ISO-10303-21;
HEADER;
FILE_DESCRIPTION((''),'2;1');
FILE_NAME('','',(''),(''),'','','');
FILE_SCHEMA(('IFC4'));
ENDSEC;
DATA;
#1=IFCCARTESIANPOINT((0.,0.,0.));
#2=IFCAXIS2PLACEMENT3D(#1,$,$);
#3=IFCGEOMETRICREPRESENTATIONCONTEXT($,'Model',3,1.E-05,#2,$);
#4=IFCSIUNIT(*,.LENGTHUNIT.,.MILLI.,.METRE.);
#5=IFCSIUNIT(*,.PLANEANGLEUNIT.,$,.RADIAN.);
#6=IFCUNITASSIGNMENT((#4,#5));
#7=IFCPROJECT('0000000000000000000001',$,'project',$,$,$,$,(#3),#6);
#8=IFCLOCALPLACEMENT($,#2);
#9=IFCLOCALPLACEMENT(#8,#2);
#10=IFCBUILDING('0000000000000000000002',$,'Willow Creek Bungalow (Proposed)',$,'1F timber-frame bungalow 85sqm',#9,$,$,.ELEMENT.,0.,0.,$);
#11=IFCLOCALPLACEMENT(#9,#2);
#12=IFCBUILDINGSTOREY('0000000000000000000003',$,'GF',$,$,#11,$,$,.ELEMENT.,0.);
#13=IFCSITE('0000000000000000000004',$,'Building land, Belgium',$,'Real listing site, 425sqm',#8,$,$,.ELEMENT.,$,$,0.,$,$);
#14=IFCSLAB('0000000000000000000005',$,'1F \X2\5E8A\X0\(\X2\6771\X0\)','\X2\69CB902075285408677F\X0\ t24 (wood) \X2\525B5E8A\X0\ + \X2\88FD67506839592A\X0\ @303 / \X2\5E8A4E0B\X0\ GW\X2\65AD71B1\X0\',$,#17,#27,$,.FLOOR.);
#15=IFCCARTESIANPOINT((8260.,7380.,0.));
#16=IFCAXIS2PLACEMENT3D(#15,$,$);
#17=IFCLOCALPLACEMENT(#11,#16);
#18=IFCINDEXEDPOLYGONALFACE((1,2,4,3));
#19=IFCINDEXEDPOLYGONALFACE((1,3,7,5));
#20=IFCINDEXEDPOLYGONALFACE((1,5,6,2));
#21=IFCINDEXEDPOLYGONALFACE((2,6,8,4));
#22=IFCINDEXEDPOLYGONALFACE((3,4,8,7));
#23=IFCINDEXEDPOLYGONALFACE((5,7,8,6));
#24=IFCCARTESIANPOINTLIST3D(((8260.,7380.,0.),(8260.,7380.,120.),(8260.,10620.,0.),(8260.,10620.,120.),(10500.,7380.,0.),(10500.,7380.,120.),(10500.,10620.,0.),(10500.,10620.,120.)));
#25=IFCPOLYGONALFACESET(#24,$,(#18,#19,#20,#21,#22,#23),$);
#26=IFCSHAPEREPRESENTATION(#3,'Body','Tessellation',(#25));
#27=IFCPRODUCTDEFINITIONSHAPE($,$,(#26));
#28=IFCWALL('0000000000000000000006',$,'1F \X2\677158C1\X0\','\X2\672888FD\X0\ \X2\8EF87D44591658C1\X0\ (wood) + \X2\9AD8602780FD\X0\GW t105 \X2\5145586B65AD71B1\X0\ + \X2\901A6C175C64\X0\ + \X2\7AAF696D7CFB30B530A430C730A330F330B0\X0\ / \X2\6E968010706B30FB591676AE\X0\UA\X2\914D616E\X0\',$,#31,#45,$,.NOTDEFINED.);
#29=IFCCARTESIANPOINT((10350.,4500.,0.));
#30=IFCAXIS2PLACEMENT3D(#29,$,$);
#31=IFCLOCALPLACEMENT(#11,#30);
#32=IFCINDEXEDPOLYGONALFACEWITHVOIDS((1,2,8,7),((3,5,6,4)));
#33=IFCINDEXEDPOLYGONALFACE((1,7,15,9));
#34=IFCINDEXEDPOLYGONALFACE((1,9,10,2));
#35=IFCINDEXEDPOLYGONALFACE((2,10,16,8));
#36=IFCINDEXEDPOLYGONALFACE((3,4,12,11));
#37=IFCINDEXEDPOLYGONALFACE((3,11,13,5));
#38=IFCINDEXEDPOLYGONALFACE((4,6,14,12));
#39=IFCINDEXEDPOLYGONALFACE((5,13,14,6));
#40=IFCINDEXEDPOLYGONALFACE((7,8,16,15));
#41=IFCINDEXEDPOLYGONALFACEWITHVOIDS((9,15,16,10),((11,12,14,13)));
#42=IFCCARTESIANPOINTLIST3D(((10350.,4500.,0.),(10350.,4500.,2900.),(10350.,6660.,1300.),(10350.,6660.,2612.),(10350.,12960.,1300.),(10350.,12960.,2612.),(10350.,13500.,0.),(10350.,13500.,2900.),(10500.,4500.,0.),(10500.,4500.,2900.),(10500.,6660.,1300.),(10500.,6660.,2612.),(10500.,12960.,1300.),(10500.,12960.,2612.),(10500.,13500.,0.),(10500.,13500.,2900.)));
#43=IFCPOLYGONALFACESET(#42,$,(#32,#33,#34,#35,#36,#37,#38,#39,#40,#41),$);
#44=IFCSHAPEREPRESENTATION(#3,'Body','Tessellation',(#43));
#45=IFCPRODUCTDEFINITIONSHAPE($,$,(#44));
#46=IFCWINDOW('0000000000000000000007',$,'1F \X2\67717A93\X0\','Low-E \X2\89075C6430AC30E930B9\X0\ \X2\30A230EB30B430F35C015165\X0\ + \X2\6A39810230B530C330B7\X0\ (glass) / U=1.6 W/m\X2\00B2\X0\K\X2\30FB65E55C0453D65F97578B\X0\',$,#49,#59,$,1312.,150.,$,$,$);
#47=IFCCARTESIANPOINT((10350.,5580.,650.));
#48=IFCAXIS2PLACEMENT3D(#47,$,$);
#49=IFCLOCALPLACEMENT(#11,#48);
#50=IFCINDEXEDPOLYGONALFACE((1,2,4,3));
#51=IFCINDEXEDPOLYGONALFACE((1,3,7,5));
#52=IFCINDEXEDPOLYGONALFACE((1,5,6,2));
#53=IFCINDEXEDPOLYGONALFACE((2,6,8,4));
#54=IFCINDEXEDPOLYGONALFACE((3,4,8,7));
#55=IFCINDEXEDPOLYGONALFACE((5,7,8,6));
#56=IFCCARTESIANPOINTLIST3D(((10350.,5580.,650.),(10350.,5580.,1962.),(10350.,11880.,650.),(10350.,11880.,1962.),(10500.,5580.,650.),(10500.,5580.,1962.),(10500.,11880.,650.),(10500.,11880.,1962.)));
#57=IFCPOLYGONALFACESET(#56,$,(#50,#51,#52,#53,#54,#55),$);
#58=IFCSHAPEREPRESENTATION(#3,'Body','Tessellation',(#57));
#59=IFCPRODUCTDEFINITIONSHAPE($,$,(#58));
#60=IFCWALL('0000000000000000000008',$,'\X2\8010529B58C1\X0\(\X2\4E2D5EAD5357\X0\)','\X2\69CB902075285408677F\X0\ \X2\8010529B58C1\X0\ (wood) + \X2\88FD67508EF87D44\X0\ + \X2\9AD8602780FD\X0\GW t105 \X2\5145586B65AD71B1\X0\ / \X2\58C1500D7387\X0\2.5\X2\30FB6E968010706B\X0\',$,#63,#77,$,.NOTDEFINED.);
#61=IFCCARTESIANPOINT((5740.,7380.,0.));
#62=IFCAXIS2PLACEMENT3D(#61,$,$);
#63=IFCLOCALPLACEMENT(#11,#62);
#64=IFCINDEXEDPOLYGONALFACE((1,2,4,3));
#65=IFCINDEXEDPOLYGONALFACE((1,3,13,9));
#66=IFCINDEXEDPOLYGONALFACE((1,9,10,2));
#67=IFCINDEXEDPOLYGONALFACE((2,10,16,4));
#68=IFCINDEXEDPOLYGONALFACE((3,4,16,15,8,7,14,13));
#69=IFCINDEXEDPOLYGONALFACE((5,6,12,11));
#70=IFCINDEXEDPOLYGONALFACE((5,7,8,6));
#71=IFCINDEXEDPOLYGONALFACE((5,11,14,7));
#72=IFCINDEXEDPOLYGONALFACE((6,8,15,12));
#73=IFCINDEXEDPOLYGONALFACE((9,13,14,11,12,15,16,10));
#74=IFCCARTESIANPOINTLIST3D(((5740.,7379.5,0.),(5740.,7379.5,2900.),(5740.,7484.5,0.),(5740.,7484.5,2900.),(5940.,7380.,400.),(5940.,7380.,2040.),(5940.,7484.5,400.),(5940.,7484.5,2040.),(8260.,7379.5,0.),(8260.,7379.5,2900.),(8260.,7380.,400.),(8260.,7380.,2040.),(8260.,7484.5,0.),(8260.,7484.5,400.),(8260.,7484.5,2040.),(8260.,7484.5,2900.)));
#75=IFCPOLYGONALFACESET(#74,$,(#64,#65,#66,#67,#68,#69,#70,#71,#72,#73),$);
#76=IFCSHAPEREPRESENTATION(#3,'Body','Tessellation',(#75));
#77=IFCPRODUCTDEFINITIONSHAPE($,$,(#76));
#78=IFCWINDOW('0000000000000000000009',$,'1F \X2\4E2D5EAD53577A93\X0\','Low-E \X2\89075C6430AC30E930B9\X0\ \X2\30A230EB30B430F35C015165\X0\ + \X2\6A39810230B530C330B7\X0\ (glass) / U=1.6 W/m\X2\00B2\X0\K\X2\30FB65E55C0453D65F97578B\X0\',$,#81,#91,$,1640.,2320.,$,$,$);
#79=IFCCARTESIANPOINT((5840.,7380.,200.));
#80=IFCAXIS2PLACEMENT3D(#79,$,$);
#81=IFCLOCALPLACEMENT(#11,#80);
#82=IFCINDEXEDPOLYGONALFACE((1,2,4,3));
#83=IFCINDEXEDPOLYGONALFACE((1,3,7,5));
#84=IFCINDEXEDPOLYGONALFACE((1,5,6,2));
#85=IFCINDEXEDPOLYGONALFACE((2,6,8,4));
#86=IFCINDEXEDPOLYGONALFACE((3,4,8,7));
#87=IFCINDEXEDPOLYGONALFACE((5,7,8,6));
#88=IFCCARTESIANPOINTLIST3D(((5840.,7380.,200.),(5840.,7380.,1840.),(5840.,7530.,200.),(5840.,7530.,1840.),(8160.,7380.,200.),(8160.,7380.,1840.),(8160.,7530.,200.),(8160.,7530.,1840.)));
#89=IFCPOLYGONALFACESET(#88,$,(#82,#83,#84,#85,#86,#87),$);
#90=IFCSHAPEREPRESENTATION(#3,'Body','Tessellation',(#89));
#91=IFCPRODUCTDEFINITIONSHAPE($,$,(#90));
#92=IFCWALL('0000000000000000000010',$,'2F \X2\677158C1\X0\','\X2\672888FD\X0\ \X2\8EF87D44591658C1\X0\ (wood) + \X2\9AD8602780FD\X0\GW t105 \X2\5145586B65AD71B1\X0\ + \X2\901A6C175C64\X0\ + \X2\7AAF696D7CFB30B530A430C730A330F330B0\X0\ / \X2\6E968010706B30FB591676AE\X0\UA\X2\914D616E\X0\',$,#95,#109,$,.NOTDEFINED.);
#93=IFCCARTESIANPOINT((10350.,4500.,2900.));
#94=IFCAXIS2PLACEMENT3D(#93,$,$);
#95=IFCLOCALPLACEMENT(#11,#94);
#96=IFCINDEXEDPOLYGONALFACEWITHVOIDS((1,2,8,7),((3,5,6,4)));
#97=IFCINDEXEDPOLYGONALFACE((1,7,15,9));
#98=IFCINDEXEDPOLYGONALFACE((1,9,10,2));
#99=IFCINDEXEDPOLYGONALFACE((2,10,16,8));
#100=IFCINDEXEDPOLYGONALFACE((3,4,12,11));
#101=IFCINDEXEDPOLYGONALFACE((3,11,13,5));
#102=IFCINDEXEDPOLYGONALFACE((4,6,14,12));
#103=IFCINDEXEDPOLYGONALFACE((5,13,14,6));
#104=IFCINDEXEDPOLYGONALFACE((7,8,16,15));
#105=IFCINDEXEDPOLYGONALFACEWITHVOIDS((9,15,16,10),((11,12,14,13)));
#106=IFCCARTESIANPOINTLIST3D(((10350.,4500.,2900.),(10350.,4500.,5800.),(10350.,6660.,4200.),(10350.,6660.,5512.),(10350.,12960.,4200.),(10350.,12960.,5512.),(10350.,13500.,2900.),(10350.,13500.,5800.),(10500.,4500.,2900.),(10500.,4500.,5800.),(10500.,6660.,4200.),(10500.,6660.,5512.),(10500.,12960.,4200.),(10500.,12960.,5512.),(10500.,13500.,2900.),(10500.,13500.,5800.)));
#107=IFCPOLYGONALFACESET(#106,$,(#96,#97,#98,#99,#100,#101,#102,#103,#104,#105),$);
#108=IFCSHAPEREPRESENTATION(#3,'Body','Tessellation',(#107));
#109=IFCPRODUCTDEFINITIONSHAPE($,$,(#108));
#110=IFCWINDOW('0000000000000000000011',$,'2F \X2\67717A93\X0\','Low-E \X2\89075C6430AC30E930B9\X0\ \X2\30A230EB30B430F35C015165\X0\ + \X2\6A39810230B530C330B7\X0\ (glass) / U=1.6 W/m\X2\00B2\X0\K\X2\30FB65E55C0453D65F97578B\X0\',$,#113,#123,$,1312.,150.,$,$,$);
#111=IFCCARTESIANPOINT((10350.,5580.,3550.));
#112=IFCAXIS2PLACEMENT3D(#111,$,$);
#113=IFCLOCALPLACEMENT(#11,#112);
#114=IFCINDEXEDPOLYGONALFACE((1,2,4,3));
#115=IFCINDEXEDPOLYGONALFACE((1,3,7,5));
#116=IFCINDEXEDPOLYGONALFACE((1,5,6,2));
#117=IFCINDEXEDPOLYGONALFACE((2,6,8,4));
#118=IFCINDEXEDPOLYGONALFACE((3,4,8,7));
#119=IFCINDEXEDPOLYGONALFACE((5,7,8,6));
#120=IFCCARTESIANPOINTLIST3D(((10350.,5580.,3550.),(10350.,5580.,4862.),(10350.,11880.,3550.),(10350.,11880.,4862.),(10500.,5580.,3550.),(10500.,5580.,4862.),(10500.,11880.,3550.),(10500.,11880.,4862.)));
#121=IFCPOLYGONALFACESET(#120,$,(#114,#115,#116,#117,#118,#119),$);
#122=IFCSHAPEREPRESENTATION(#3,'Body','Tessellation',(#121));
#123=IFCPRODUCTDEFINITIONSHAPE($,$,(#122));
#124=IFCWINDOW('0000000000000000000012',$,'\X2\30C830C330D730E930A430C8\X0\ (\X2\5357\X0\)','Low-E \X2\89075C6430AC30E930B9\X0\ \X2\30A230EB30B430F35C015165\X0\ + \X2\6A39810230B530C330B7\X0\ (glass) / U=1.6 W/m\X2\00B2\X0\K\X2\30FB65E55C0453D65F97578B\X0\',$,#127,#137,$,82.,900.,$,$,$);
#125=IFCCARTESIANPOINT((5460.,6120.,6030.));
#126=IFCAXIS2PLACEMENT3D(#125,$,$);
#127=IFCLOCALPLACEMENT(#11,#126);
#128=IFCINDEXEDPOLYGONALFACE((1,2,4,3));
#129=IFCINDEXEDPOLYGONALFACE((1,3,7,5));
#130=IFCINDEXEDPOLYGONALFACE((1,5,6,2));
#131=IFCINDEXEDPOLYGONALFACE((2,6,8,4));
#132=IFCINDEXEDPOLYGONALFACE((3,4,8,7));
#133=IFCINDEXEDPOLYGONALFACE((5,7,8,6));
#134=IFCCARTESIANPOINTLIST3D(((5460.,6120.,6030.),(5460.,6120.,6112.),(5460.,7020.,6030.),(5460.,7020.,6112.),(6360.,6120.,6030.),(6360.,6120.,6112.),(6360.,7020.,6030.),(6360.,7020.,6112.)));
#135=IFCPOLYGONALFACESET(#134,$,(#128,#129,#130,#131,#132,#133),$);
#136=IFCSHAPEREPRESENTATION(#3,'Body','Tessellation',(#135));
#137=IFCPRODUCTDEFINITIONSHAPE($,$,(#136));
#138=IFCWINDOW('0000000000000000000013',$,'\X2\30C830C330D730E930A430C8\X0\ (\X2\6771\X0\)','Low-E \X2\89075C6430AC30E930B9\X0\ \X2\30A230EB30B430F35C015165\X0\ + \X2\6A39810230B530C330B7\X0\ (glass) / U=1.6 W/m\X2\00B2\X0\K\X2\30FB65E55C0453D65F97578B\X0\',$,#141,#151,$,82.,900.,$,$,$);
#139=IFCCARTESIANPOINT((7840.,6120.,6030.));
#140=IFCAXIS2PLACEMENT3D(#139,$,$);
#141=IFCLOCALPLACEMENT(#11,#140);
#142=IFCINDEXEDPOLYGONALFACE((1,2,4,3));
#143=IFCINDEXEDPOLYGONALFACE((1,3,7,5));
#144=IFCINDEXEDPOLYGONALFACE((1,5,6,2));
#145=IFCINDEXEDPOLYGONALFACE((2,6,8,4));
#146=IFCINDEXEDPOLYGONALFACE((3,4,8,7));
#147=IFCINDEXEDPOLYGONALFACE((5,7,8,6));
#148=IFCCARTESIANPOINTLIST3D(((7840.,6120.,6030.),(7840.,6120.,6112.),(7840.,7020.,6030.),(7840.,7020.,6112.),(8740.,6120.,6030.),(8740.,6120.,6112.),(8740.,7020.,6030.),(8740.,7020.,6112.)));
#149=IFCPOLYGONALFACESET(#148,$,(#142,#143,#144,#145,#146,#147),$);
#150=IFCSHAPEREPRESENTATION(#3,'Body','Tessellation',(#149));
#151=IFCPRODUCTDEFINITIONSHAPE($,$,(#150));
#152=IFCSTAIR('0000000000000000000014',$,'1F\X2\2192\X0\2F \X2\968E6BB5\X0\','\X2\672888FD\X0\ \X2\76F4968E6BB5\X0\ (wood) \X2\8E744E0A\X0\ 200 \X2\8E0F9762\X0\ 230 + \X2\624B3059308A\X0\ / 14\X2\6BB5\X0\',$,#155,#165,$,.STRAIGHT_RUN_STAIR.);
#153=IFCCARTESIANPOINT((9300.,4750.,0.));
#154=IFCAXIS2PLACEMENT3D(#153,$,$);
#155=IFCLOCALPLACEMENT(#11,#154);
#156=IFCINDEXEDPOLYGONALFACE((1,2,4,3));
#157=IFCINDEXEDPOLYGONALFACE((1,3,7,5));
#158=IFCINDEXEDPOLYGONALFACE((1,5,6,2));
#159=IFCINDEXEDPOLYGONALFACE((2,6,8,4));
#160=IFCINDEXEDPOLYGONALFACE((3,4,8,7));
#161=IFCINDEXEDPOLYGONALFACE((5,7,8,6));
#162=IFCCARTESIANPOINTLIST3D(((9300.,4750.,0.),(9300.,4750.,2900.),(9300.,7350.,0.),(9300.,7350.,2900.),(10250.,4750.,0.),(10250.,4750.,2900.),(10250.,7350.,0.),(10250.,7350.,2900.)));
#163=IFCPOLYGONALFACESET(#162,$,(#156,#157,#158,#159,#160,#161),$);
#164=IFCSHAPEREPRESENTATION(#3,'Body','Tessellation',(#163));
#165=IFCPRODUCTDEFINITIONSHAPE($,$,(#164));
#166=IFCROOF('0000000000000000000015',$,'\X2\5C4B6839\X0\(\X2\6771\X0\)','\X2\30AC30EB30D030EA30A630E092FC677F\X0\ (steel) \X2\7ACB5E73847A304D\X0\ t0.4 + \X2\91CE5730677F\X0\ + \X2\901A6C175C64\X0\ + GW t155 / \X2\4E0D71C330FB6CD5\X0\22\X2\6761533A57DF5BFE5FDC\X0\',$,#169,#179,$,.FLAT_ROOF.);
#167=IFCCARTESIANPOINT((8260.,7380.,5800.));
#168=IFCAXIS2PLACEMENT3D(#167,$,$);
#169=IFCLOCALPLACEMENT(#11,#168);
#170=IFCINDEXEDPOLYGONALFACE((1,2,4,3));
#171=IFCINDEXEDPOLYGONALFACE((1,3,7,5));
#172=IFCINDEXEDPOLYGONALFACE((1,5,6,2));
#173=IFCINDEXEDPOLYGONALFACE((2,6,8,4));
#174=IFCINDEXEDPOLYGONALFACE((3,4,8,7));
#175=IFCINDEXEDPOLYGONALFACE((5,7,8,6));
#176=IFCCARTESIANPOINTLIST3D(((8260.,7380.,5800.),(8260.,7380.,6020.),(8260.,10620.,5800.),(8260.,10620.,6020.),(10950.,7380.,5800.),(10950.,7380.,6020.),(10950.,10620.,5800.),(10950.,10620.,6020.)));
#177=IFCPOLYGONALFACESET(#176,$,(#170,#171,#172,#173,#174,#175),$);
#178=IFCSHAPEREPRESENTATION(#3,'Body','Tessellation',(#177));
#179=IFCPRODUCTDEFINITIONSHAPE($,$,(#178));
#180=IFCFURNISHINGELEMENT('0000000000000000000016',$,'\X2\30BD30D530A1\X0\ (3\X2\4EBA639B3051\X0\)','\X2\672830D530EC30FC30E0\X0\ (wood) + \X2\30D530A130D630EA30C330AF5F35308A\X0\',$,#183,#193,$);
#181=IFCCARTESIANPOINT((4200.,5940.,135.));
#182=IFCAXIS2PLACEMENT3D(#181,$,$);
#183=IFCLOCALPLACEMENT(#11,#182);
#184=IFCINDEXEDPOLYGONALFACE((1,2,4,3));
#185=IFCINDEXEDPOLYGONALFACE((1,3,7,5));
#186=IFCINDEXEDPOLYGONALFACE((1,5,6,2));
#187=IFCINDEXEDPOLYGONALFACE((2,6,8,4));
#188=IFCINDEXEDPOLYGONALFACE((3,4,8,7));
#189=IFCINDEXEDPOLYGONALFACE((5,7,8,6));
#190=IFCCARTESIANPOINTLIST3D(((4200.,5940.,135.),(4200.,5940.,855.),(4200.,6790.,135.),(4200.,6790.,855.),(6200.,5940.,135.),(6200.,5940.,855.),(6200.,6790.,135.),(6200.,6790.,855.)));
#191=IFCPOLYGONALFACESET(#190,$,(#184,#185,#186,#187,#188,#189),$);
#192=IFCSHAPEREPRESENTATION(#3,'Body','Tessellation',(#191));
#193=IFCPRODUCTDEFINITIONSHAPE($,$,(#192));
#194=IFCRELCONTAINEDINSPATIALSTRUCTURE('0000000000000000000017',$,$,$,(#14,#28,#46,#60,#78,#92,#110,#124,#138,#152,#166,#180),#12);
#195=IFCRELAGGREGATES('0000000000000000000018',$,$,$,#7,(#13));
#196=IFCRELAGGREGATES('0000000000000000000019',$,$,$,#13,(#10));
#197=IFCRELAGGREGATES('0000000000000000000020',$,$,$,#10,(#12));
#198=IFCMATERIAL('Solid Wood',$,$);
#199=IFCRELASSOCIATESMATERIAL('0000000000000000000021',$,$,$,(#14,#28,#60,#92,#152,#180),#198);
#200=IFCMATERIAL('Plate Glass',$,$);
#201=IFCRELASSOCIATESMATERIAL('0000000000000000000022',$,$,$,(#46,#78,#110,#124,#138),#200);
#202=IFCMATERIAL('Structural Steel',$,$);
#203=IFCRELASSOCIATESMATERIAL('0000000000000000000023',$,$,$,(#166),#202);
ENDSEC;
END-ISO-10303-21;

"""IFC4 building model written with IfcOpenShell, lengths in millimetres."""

from ifc_helpers import new_model, si_unit, frame, frame_2d, origin, place, context, project, spatial, rectangle, extrude, material, element, fill, save


model = new_model("IFC4")

# Units and contexts
model_context = context("Model", 3, precision=1e-05, world=origin())
ifc_project = project(units=[si_unit("LENGTHUNIT", "METRE", prefix="MILLI"), si_unit("PLANEANGLEUNIT", "RADIAN")], contexts=[model_context])

# Site, building, storey
site_placement = place(None, origin())
site = spatial("IfcSite", under=ifc_project, at=site_placement, Name="Building land, Belgium", ObjectType="Real listing site, 425sqm", CompositionType="ELEMENT", RefElevation=0.0)
building_placement = place(site_placement, origin())
building = spatial("IfcBuilding", under=site, at=building_placement, Name="Willow Creek Bungalow (Proposed)", ObjectType="1F timber-frame bungalow 85sqm", CompositionType="ELEMENT", ElevationOfRefHeight=0.0, ElevationOfTerrain=0.0)
storey_placement = place(building_placement, origin())
storey = spatial("IfcBuildingStorey", under=building, at=storey_placement, Name="GF", CompositionType="ELEMENT", Elevation=0.0)

# Slab
ifc_material_1 = material(Name="Solid Wood")
slab_placement = place(storey_placement, frame((8260.0, 7380.0, 0.0)))
element("IfcSlab", 1, at=slab_placement, inside=storey, material=ifc_material_1, Name="1F 床(東)", Description="構造用合板 t24 (wood) 剛床 + 製材根太 @303 / 床下 GW断熱", PredefinedType="FLOOR", context=model_context, shape_type="SweptSolid", body=[
    extrude(rectangle(XDim=2240.0, YDim=3240.0, at=frame_2d((1120.0, 1620.0))), frame((8260.0, 7380.0, 0.0)), (0.0, 0.0, 1.0), 120.0),
])

# Walls, openings, windows
wall_1_placement = place(storey_placement, frame((10350.0, 4500.0, 0.0)))
wall_1 = element("IfcWall", 2, at=wall_1_placement, inside=storey, material=ifc_material_1, Name="1F 東壁", Description="木製 軸組外壁 (wood) + 高性能GW t105 充填断熱 + 通気層 + 窯業系サイディング / 準耐火・外皮UA配慮", PredefinedType="NOTDEFINED", context=model_context, shape_type="SweptSolid", body=[
    extrude(rectangle(XDim=150.0, YDim=9000.0, at=frame_2d((75.0, 4500.0))), frame((10350.0, 4500.0, 0.0)), (0.0, 0.0, 1.0), 2900.0),
])
opening_1_placement = place(storey_placement, frame((10350.0, 5580.0, 650.0)))
opening_1 = element("IfcOpeningElement", 3, at=opening_1_placement, cuts=wall_1, PredefinedType="NOTDEFINED", context=model_context, shape_type="SweptSolid", body=[
    extrude(rectangle(XDim=150.0, YDim=6300.0, at=frame_2d((75.0, 3150.0))), frame((10350.0, 5580.0, 650.0)), (0.0, 0.0, 1.0), 1312.0),
])
ifc_material_2 = material(Name="Plate Glass")
window_1_placement = place(storey_placement, frame((10350.0, 5580.0, 650.0)))
window_1 = element("IfcWindow", 4, at=window_1_placement, inside=storey, material=ifc_material_2, Name="1F 東窓", Description="Low-E 複層ガラス アルゴン封入 + 樹脂サッシ (glass) / U=1.6 W/m²K・日射取得型", OverallHeight=1312.0, OverallWidth=150.0, context=model_context, shape_type="SweptSolid", body=[
    extrude(rectangle(XDim=150.0, YDim=6300.0, at=frame_2d((75.0, 3150.0))), frame((10350.0, 5580.0, 650.0)), (0.0, 0.0, 1.0), 1312.0),
])
fill(opening_1, window_1)
wall_2_placement = place(storey_placement, frame((5740.0, 7380.0, 0.0)))
wall_2 = element("IfcWall", 5, at=wall_2_placement, inside=storey, material=ifc_material_1, Name="耐力壁(中庭南)", Description="構造用合板 耐力壁 (wood) + 製材軸組 + 高性能GW t105 充填断熱 / 壁倍率2.5・準耐火", PredefinedType="NOTDEFINED", context=model_context, shape_type="SweptSolid", body=[
    extrude(rectangle(XDim=2520.0, YDim=105.0, at=frame_2d((1260.0, 52.0))), frame((5740.0, 7380.0, 0.0)), (0.0, 0.0, 1.0), 2900.0),
])
opening_2_placement = place(storey_placement, frame((5840.0, 7380.0, 200.0)))
opening_2 = element("IfcOpeningElement", 6, at=opening_2_placement, cuts=wall_2, PredefinedType="NOTDEFINED", context=model_context, shape_type="SweptSolid", body=[
    extrude(rectangle(XDim=2320.0, YDim=150.0, at=frame_2d((1160.0, 75.0))), frame((5840.0, 7380.0, 200.0)), (0.0, 0.0, 1.0), 1640.0),
])
window_2_placement = place(storey_placement, frame((5840.0, 7380.0, 200.0)))
window_2 = element("IfcWindow", 7, at=window_2_placement, inside=storey, material=ifc_material_2, Name="1F 中庭南窓", Description="Low-E 複層ガラス アルゴン封入 + 樹脂サッシ (glass) / U=1.6 W/m²K・日射取得型", OverallHeight=1640.0, OverallWidth=2320.0, context=model_context, shape_type="SweptSolid", body=[
    extrude(rectangle(XDim=2320.0, YDim=150.0, at=frame_2d((1160.0, 75.0))), frame((5840.0, 7380.0, 200.0)), (0.0, 0.0, 1.0), 1640.0),
])
fill(opening_2, window_2)

# Wall, opening, window
wall_3_placement = place(storey_placement, frame((10350.0, 4500.0, 2900.0)))
wall_3 = element("IfcWall", 8, at=wall_3_placement, inside=storey, material=ifc_material_1, Name="2F 東壁", Description="木製 軸組外壁 (wood) + 高性能GW t105 充填断熱 + 通気層 + 窯業系サイディング / 準耐火・外皮UA配慮", PredefinedType="NOTDEFINED", context=model_context, shape_type="SweptSolid", body=[
    extrude(rectangle(XDim=150.0, YDim=9000.0, at=frame_2d((75.0, 4500.0))), frame((10350.0, 4500.0, 2900.0)), (0.0, 0.0, 1.0), 2900.0),
])
opening_3_placement = place(storey_placement, frame((10350.0, 5580.0, 3550.0)))
opening_3 = element("IfcOpeningElement", 9, at=opening_3_placement, cuts=wall_3, PredefinedType="NOTDEFINED", context=model_context, shape_type="SweptSolid", body=[
    extrude(rectangle(XDim=150.0, YDim=6300.0, at=frame_2d((75.0, 3150.0))), frame((10350.0, 5580.0, 3550.0)), (0.0, 0.0, 1.0), 1312.0),
])
window_3_placement = place(storey_placement, frame((10350.0, 5580.0, 3550.0)))
window_3 = element("IfcWindow", 10, at=window_3_placement, inside=storey, material=ifc_material_2, Name="2F 東窓", Description="Low-E 複層ガラス アルゴン封入 + 樹脂サッシ (glass) / U=1.6 W/m²K・日射取得型", OverallHeight=1312.0, OverallWidth=150.0, context=model_context, shape_type="SweptSolid", body=[
    extrude(rectangle(XDim=150.0, YDim=6300.0, at=frame_2d((75.0, 3150.0))), frame((10350.0, 5580.0, 3550.0)), (0.0, 0.0, 1.0), 1312.0),
])
fill(opening_3, window_3)

# Windows
window_4_placement = place(storey_placement, frame((5460.0, 6120.0, 6030.0)))
element("IfcWindow", 11, at=window_4_placement, inside=storey, material=ifc_material_2, Name="トップライト (南)", Description="Low-E 複層ガラス アルゴン封入 + 樹脂サッシ (glass) / U=1.6 W/m²K・日射取得型", OverallHeight=82.0, OverallWidth=900.0, context=model_context, shape_type="SweptSolid", body=[
    extrude(rectangle(XDim=900.0, YDim=900.0, at=frame_2d((450.0, 450.0))), frame((5460.0, 6120.0, 6030.0)), (0.0, 0.0, 1.0), 82.0),
])
window_5_placement = place(storey_placement, frame((7840.0, 6120.0, 6030.0)))
element("IfcWindow", 12, at=window_5_placement, inside=storey, material=ifc_material_2, Name="トップライト (東)", Description="Low-E 複層ガラス アルゴン封入 + 樹脂サッシ (glass) / U=1.6 W/m²K・日射取得型", OverallHeight=82.0, OverallWidth=900.0, context=model_context, shape_type="SweptSolid", body=[
    extrude(rectangle(XDim=900.0, YDim=900.0, at=frame_2d((450.0, 450.0))), frame((7840.0, 6120.0, 6030.0)), (0.0, 0.0, 1.0), 82.0),
])

# Stair
stair_placement = place(storey_placement, frame((9300.0, 4750.0, 0.0)))
element("IfcStair", 13, at=stair_placement, inside=storey, material=ifc_material_1, Name="1F→2F 階段", Description="木製 直階段 (wood) 蹴上 200 踏面 230 + 手すり / 14段", PredefinedType="STRAIGHT_RUN_STAIR", context=model_context, shape_type="SweptSolid", body=[
    extrude(rectangle(XDim=950.0, YDim=2600.0, at=frame_2d((475.0, 1300.0))), frame((9300.0, 4750.0, 0.0)), (0.0, 0.0, 1.0), 2900.0),
])

# Roof
ifc_material_3 = material(Name="Structural Steel")
roof_placement = place(storey_placement, frame((8260.0, 7380.0, 5800.0)))
element("IfcRoof", 14, at=roof_placement, inside=storey, material=ifc_material_3, Name="屋根(東)", Description="ガルバリウム鋼板 (steel) 立平葺き t0.4 + 野地板 + 通気層 + GW t155 / 不燃・法22条区域対応", PredefinedType="FLAT_ROOF", context=model_context, shape_type="SweptSolid", body=[
    extrude(rectangle(XDim=2690.0, YDim=3240.0, at=frame_2d((1345.0, 1620.0))), frame((8260.0, 7380.0, 5800.0)), (0.0, 0.0, 1.0), 220.0),
])

# Furnishing element
furnishing_1_placement = place(storey_placement, frame((4200.0, 5940.0, 135.0)))
element("IfcFurnishingElement", 15, at=furnishing_1_placement, inside=storey, material=ifc_material_1, Name="ソファ (3人掛け)", Description="木フレーム (wood) + ファブリック張り", context=model_context, shape_type="SweptSolid", body=[
    extrude(rectangle(XDim=2000.0, YDim=850.0, at=frame_2d((1000.0, 425.0))), frame((4200.0, 5940.0, 135.0)), (0.0, 0.0, 1.0), 720.0),
])

save(model, "model.ifc")
